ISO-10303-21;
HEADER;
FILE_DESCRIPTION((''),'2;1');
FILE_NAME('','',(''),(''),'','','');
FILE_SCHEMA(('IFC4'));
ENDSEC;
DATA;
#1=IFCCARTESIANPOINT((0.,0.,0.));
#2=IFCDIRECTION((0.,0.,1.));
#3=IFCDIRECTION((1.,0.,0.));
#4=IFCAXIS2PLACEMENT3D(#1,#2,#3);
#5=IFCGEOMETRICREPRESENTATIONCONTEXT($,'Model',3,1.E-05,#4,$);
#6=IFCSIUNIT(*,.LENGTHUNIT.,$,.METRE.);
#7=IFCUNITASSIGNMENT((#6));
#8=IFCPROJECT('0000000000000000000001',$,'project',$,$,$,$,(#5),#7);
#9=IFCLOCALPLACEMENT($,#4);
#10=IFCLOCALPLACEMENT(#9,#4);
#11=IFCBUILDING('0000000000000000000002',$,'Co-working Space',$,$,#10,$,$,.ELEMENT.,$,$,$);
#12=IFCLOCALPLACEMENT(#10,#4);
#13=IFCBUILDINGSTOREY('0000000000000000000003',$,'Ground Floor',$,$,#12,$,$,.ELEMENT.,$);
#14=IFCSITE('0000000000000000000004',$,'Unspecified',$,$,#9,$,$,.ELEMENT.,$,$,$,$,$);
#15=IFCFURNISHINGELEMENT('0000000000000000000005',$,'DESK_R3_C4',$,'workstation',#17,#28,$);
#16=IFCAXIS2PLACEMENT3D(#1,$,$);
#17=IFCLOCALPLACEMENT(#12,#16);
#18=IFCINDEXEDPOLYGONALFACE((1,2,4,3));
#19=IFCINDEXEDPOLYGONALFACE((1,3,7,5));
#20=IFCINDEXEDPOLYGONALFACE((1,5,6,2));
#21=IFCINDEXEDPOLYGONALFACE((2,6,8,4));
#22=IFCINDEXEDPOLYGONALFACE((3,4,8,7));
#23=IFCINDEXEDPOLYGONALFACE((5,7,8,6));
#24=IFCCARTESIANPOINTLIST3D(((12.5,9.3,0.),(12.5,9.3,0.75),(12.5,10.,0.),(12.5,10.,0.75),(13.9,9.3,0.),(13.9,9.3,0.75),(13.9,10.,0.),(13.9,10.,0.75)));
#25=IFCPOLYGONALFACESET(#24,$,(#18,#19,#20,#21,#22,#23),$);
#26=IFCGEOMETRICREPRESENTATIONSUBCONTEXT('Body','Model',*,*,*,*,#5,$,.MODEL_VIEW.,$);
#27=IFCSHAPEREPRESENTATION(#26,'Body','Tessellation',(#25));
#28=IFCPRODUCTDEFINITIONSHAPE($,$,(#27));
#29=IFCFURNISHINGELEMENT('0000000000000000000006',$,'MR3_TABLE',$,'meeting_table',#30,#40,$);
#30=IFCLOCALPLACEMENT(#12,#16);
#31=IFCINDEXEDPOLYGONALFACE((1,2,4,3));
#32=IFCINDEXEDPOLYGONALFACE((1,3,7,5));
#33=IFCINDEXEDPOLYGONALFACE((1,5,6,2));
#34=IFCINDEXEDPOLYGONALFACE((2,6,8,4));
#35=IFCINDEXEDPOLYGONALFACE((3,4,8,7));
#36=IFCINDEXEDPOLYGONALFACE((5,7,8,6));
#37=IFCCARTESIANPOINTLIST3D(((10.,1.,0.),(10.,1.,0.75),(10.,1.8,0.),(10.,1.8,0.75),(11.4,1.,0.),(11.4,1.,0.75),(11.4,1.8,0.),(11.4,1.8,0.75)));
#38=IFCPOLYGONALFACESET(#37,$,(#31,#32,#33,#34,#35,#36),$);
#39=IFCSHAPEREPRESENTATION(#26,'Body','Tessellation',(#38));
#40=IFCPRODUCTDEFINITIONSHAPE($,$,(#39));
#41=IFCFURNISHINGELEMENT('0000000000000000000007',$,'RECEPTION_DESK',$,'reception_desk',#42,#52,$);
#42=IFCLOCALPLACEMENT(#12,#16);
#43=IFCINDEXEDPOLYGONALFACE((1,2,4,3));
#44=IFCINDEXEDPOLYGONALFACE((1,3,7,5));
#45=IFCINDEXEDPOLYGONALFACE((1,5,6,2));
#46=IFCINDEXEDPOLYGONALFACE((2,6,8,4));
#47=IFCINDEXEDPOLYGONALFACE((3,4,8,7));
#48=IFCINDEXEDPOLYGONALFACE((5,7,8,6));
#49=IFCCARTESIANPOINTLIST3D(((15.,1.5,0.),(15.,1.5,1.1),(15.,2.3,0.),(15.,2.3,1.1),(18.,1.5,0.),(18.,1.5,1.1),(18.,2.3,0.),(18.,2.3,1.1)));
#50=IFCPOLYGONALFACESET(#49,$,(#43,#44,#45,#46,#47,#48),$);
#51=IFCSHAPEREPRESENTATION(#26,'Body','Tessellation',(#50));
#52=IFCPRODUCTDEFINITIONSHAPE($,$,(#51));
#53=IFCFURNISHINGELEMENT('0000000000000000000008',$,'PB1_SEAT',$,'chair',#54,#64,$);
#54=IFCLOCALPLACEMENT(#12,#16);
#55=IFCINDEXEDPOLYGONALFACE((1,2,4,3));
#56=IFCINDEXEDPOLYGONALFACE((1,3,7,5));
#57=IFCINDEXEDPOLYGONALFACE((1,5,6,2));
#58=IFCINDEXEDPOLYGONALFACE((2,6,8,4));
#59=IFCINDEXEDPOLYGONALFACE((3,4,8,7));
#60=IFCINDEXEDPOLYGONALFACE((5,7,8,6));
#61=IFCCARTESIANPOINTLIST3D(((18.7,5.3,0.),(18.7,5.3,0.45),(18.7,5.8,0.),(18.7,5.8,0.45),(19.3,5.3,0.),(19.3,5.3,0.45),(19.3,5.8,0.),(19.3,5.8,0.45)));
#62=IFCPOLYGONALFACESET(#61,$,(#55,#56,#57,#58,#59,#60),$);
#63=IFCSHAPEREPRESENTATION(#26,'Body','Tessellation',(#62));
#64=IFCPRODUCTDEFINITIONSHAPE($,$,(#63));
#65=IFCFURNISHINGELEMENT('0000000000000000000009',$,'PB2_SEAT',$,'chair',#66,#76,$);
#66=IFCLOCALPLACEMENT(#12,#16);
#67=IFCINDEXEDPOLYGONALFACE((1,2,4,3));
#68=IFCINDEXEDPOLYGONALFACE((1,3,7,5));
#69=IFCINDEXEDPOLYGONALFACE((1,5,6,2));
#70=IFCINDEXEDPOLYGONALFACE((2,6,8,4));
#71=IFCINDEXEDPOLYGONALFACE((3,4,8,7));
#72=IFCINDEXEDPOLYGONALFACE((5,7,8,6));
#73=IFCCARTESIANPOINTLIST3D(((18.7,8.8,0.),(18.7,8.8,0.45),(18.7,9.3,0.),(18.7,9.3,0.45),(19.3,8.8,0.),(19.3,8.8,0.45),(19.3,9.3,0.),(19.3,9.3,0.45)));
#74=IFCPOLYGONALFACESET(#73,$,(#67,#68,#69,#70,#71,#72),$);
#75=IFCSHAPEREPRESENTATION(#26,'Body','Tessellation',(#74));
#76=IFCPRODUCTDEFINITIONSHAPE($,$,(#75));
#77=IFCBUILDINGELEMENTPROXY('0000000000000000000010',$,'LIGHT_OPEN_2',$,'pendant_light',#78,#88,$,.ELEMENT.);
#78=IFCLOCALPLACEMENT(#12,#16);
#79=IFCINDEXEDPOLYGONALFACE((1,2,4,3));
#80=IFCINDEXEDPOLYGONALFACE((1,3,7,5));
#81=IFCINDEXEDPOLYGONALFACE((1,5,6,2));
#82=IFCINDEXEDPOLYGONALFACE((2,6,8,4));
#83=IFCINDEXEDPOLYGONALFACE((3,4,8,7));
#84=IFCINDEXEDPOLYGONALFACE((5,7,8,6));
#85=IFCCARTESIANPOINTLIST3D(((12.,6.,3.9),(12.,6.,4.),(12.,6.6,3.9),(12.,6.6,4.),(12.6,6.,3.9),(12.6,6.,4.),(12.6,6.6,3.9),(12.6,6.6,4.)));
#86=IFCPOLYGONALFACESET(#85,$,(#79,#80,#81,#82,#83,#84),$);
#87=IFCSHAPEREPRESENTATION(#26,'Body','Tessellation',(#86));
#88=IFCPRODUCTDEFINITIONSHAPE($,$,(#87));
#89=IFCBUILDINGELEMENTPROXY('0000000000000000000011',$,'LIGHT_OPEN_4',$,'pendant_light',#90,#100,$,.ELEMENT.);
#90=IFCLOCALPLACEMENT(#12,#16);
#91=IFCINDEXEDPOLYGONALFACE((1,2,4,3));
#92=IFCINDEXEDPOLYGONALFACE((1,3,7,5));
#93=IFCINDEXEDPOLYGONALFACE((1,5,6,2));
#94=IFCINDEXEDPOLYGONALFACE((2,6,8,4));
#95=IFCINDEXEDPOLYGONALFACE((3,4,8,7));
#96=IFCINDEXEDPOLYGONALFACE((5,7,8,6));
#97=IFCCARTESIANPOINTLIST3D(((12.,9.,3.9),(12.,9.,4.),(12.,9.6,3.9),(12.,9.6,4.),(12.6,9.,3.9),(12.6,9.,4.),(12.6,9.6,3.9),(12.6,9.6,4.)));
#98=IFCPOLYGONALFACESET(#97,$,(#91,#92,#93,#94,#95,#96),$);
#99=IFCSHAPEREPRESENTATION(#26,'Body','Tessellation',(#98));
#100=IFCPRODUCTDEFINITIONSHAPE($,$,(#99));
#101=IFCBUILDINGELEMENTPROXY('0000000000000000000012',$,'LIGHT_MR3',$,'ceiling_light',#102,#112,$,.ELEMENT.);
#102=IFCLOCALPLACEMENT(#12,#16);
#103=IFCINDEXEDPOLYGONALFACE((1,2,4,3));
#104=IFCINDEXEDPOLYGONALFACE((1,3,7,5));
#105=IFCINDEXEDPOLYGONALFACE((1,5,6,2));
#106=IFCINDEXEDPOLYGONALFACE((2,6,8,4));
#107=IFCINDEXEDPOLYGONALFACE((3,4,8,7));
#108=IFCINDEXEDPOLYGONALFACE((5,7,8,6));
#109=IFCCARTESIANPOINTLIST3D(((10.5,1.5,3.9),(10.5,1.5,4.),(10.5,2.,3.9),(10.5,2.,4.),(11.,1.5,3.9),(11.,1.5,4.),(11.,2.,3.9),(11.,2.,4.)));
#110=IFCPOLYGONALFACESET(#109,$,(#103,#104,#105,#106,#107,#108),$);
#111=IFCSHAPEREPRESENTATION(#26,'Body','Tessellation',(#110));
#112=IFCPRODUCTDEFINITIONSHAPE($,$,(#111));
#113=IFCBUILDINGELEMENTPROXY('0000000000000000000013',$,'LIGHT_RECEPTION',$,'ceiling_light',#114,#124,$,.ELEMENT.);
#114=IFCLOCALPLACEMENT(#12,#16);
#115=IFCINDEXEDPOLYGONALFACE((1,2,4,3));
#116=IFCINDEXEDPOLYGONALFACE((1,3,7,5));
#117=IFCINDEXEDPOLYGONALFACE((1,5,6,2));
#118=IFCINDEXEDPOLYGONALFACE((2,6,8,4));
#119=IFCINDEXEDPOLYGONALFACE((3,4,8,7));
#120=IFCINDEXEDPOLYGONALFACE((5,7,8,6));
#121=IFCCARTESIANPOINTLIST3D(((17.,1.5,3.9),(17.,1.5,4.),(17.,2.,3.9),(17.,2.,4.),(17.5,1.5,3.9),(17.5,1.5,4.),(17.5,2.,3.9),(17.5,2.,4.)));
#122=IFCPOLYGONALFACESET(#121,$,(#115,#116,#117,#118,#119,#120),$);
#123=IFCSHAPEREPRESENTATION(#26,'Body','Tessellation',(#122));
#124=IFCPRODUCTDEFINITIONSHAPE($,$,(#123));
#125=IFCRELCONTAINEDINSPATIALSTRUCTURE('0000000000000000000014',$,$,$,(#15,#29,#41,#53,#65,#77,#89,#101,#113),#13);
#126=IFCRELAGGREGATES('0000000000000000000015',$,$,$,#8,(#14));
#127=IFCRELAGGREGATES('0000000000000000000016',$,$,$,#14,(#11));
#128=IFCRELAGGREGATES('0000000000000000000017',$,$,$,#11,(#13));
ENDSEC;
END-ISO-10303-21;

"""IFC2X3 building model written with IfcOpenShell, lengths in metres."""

from ifc_helpers import new_model, si_unit, frame, frame_2d, origin, origin_with_axes, place, context, subcontext, project, spatial, rectangle, extrude, element, save


model = new_model("IFC2X3")

# Units and contexts
model_context = context("Model", 3, precision=1e-05, world=origin_with_axes())
body_context = subcontext(model_context, "Body", "Model", "MODEL_VIEW")
ifc_project = project(units=[si_unit("LENGTHUNIT", "METRE")], contexts=[model_context])

# Site, building, storey
site_placement = place(None, origin_with_axes())
site = spatial("IfcSite", under=ifc_project, at=site_placement, Name="Unspecified", CompositionType="ELEMENT")
building_placement = place(site_placement, origin_with_axes())
building = spatial("IfcBuilding", under=site, at=building_placement, Name="Co-working Space", CompositionType="ELEMENT")
storey_placement = place(building_placement, origin_with_axes())
storey = spatial("IfcBuildingStorey", under=building, at=storey_placement, Name="Ground Floor", CompositionType="ELEMENT")

# Furnishing elements
for number, where, z_axis, x_axis, name in (
    (1, (12.5, 9.3, 0.0), (0.0, 0.0, 1.0), (1.0, 0.0, 0.0), "DESK_R3_C4"),
):
    element("IfcFurnishingElement", number, at=place(storey_placement, frame(where, z_axis=z_axis, x_axis=x_axis)), inside=storey, Name=name, ObjectType="workstation", context=body_context, shape_type="SweptSolid", body=[
        extrude(rectangle(XDim=1.4, YDim=0.7, at=frame_2d((0.7, 0.35))), origin(), (0.0, 0.0, 1.0), 0.75),
    ])
furnishing_1_placement = place(storey_placement, frame((10.0, 1.0, 0.0), z_axis=(0.0, 0.0, 1.0), x_axis=(1.0, 0.0, 0.0)))
element("IfcFurnishingElement", 2, at=furnishing_1_placement, inside=storey, Name="MR3_TABLE", ObjectType="meeting_table", context=body_context, shape_type="SweptSolid", body=[
    extrude(rectangle(XDim=1.4, YDim=0.8, at=frame_2d((0.7, 0.4))), origin(), (0.0, 0.0, 1.0), 0.75),
])
furnishing_2_placement = place(storey_placement, frame((15.0, 1.5, 0.0), z_axis=(0.0, 0.0, 1.0), x_axis=(1.0, 0.0, 0.0)))
element("IfcFurnishingElement", 3, at=furnishing_2_placement, inside=storey, Name="RECEPTION_DESK", ObjectType="reception_desk", context=body_context, shape_type="SweptSolid", body=[
    extrude(rectangle(XDim=3.0, YDim=0.8, at=frame_2d((1.5, 0.4))), origin(), (0.0, 0.0, 1.0), 1.1),
])
for number, where, z_axis, x_axis, name in (
    (4, (18.7, 5.3, 0.0), (0.0, 0.0, 1.0), (1.0, 0.0, 0.0), "PB1_SEAT"),
    (5, (18.7, 8.8, 0.0), (0.0, 0.0, 1.0), (1.0, 0.0, 0.0), "PB2_SEAT"),
):
    element("IfcFurnishingElement", number, at=place(storey_placement, frame(where, z_axis=z_axis, x_axis=x_axis)), inside=storey, Name=name, ObjectType="chair", context=body_context, shape_type="SweptSolid", body=[
        extrude(rectangle(XDim=0.6, YDim=0.5, at=frame_2d((0.3, 0.25))), origin(), (0.0, 0.0, 1.0), 0.45),
    ])

# Building element proxies
for number, where, z_axis, x_axis, name in (
    (6, (12.0, 6.0, 3.9), (0.0, 0.0, 1.0), (1.0, 0.0, 0.0), "LIGHT_OPEN_2"),
    (7, (12.0, 9.0, 3.9), (0.0, 0.0, 1.0), (1.0, 0.0, 0.0), "LIGHT_OPEN_4"),
):
    element("IfcBuildingElementProxy", number, at=place(storey_placement, frame(where, z_axis=z_axis, x_axis=x_axis)), inside=storey, Name=name, ObjectType="pendant_light", CompositionType="ELEMENT", context=body_context, shape_type="SweptSolid", body=[
        extrude(rectangle(XDim=0.6, YDim=0.6, at=frame_2d((0.3, 0.3))), origin(), (0.0, 0.0, 1.0), 0.1),
    ])
for number, where, z_axis, x_axis, name in (
    (8, (10.5, 1.5, 3.9), (0.0, 0.0, 1.0), (1.0, 0.0, 0.0), "LIGHT_MR3"),
    (9, (17.0, 1.5, 3.9), (0.0, 0.0, 1.0), (1.0, 0.0, 0.0), "LIGHT_RECEPTION"),
):
    element("IfcBuildingElementProxy", number, at=place(storey_placement, frame(where, z_axis=z_axis, x_axis=x_axis)), inside=storey, Name=name, ObjectType="ceiling_light", CompositionType="ELEMENT", context=body_context, shape_type="SweptSolid", body=[
        extrude(rectangle(XDim=0.5, YDim=0.5, at=frame_2d((0.25, 0.25))), origin(), (0.0, 0.0, 1.0), 0.1),
    ])

save(model, "model.ifc")
